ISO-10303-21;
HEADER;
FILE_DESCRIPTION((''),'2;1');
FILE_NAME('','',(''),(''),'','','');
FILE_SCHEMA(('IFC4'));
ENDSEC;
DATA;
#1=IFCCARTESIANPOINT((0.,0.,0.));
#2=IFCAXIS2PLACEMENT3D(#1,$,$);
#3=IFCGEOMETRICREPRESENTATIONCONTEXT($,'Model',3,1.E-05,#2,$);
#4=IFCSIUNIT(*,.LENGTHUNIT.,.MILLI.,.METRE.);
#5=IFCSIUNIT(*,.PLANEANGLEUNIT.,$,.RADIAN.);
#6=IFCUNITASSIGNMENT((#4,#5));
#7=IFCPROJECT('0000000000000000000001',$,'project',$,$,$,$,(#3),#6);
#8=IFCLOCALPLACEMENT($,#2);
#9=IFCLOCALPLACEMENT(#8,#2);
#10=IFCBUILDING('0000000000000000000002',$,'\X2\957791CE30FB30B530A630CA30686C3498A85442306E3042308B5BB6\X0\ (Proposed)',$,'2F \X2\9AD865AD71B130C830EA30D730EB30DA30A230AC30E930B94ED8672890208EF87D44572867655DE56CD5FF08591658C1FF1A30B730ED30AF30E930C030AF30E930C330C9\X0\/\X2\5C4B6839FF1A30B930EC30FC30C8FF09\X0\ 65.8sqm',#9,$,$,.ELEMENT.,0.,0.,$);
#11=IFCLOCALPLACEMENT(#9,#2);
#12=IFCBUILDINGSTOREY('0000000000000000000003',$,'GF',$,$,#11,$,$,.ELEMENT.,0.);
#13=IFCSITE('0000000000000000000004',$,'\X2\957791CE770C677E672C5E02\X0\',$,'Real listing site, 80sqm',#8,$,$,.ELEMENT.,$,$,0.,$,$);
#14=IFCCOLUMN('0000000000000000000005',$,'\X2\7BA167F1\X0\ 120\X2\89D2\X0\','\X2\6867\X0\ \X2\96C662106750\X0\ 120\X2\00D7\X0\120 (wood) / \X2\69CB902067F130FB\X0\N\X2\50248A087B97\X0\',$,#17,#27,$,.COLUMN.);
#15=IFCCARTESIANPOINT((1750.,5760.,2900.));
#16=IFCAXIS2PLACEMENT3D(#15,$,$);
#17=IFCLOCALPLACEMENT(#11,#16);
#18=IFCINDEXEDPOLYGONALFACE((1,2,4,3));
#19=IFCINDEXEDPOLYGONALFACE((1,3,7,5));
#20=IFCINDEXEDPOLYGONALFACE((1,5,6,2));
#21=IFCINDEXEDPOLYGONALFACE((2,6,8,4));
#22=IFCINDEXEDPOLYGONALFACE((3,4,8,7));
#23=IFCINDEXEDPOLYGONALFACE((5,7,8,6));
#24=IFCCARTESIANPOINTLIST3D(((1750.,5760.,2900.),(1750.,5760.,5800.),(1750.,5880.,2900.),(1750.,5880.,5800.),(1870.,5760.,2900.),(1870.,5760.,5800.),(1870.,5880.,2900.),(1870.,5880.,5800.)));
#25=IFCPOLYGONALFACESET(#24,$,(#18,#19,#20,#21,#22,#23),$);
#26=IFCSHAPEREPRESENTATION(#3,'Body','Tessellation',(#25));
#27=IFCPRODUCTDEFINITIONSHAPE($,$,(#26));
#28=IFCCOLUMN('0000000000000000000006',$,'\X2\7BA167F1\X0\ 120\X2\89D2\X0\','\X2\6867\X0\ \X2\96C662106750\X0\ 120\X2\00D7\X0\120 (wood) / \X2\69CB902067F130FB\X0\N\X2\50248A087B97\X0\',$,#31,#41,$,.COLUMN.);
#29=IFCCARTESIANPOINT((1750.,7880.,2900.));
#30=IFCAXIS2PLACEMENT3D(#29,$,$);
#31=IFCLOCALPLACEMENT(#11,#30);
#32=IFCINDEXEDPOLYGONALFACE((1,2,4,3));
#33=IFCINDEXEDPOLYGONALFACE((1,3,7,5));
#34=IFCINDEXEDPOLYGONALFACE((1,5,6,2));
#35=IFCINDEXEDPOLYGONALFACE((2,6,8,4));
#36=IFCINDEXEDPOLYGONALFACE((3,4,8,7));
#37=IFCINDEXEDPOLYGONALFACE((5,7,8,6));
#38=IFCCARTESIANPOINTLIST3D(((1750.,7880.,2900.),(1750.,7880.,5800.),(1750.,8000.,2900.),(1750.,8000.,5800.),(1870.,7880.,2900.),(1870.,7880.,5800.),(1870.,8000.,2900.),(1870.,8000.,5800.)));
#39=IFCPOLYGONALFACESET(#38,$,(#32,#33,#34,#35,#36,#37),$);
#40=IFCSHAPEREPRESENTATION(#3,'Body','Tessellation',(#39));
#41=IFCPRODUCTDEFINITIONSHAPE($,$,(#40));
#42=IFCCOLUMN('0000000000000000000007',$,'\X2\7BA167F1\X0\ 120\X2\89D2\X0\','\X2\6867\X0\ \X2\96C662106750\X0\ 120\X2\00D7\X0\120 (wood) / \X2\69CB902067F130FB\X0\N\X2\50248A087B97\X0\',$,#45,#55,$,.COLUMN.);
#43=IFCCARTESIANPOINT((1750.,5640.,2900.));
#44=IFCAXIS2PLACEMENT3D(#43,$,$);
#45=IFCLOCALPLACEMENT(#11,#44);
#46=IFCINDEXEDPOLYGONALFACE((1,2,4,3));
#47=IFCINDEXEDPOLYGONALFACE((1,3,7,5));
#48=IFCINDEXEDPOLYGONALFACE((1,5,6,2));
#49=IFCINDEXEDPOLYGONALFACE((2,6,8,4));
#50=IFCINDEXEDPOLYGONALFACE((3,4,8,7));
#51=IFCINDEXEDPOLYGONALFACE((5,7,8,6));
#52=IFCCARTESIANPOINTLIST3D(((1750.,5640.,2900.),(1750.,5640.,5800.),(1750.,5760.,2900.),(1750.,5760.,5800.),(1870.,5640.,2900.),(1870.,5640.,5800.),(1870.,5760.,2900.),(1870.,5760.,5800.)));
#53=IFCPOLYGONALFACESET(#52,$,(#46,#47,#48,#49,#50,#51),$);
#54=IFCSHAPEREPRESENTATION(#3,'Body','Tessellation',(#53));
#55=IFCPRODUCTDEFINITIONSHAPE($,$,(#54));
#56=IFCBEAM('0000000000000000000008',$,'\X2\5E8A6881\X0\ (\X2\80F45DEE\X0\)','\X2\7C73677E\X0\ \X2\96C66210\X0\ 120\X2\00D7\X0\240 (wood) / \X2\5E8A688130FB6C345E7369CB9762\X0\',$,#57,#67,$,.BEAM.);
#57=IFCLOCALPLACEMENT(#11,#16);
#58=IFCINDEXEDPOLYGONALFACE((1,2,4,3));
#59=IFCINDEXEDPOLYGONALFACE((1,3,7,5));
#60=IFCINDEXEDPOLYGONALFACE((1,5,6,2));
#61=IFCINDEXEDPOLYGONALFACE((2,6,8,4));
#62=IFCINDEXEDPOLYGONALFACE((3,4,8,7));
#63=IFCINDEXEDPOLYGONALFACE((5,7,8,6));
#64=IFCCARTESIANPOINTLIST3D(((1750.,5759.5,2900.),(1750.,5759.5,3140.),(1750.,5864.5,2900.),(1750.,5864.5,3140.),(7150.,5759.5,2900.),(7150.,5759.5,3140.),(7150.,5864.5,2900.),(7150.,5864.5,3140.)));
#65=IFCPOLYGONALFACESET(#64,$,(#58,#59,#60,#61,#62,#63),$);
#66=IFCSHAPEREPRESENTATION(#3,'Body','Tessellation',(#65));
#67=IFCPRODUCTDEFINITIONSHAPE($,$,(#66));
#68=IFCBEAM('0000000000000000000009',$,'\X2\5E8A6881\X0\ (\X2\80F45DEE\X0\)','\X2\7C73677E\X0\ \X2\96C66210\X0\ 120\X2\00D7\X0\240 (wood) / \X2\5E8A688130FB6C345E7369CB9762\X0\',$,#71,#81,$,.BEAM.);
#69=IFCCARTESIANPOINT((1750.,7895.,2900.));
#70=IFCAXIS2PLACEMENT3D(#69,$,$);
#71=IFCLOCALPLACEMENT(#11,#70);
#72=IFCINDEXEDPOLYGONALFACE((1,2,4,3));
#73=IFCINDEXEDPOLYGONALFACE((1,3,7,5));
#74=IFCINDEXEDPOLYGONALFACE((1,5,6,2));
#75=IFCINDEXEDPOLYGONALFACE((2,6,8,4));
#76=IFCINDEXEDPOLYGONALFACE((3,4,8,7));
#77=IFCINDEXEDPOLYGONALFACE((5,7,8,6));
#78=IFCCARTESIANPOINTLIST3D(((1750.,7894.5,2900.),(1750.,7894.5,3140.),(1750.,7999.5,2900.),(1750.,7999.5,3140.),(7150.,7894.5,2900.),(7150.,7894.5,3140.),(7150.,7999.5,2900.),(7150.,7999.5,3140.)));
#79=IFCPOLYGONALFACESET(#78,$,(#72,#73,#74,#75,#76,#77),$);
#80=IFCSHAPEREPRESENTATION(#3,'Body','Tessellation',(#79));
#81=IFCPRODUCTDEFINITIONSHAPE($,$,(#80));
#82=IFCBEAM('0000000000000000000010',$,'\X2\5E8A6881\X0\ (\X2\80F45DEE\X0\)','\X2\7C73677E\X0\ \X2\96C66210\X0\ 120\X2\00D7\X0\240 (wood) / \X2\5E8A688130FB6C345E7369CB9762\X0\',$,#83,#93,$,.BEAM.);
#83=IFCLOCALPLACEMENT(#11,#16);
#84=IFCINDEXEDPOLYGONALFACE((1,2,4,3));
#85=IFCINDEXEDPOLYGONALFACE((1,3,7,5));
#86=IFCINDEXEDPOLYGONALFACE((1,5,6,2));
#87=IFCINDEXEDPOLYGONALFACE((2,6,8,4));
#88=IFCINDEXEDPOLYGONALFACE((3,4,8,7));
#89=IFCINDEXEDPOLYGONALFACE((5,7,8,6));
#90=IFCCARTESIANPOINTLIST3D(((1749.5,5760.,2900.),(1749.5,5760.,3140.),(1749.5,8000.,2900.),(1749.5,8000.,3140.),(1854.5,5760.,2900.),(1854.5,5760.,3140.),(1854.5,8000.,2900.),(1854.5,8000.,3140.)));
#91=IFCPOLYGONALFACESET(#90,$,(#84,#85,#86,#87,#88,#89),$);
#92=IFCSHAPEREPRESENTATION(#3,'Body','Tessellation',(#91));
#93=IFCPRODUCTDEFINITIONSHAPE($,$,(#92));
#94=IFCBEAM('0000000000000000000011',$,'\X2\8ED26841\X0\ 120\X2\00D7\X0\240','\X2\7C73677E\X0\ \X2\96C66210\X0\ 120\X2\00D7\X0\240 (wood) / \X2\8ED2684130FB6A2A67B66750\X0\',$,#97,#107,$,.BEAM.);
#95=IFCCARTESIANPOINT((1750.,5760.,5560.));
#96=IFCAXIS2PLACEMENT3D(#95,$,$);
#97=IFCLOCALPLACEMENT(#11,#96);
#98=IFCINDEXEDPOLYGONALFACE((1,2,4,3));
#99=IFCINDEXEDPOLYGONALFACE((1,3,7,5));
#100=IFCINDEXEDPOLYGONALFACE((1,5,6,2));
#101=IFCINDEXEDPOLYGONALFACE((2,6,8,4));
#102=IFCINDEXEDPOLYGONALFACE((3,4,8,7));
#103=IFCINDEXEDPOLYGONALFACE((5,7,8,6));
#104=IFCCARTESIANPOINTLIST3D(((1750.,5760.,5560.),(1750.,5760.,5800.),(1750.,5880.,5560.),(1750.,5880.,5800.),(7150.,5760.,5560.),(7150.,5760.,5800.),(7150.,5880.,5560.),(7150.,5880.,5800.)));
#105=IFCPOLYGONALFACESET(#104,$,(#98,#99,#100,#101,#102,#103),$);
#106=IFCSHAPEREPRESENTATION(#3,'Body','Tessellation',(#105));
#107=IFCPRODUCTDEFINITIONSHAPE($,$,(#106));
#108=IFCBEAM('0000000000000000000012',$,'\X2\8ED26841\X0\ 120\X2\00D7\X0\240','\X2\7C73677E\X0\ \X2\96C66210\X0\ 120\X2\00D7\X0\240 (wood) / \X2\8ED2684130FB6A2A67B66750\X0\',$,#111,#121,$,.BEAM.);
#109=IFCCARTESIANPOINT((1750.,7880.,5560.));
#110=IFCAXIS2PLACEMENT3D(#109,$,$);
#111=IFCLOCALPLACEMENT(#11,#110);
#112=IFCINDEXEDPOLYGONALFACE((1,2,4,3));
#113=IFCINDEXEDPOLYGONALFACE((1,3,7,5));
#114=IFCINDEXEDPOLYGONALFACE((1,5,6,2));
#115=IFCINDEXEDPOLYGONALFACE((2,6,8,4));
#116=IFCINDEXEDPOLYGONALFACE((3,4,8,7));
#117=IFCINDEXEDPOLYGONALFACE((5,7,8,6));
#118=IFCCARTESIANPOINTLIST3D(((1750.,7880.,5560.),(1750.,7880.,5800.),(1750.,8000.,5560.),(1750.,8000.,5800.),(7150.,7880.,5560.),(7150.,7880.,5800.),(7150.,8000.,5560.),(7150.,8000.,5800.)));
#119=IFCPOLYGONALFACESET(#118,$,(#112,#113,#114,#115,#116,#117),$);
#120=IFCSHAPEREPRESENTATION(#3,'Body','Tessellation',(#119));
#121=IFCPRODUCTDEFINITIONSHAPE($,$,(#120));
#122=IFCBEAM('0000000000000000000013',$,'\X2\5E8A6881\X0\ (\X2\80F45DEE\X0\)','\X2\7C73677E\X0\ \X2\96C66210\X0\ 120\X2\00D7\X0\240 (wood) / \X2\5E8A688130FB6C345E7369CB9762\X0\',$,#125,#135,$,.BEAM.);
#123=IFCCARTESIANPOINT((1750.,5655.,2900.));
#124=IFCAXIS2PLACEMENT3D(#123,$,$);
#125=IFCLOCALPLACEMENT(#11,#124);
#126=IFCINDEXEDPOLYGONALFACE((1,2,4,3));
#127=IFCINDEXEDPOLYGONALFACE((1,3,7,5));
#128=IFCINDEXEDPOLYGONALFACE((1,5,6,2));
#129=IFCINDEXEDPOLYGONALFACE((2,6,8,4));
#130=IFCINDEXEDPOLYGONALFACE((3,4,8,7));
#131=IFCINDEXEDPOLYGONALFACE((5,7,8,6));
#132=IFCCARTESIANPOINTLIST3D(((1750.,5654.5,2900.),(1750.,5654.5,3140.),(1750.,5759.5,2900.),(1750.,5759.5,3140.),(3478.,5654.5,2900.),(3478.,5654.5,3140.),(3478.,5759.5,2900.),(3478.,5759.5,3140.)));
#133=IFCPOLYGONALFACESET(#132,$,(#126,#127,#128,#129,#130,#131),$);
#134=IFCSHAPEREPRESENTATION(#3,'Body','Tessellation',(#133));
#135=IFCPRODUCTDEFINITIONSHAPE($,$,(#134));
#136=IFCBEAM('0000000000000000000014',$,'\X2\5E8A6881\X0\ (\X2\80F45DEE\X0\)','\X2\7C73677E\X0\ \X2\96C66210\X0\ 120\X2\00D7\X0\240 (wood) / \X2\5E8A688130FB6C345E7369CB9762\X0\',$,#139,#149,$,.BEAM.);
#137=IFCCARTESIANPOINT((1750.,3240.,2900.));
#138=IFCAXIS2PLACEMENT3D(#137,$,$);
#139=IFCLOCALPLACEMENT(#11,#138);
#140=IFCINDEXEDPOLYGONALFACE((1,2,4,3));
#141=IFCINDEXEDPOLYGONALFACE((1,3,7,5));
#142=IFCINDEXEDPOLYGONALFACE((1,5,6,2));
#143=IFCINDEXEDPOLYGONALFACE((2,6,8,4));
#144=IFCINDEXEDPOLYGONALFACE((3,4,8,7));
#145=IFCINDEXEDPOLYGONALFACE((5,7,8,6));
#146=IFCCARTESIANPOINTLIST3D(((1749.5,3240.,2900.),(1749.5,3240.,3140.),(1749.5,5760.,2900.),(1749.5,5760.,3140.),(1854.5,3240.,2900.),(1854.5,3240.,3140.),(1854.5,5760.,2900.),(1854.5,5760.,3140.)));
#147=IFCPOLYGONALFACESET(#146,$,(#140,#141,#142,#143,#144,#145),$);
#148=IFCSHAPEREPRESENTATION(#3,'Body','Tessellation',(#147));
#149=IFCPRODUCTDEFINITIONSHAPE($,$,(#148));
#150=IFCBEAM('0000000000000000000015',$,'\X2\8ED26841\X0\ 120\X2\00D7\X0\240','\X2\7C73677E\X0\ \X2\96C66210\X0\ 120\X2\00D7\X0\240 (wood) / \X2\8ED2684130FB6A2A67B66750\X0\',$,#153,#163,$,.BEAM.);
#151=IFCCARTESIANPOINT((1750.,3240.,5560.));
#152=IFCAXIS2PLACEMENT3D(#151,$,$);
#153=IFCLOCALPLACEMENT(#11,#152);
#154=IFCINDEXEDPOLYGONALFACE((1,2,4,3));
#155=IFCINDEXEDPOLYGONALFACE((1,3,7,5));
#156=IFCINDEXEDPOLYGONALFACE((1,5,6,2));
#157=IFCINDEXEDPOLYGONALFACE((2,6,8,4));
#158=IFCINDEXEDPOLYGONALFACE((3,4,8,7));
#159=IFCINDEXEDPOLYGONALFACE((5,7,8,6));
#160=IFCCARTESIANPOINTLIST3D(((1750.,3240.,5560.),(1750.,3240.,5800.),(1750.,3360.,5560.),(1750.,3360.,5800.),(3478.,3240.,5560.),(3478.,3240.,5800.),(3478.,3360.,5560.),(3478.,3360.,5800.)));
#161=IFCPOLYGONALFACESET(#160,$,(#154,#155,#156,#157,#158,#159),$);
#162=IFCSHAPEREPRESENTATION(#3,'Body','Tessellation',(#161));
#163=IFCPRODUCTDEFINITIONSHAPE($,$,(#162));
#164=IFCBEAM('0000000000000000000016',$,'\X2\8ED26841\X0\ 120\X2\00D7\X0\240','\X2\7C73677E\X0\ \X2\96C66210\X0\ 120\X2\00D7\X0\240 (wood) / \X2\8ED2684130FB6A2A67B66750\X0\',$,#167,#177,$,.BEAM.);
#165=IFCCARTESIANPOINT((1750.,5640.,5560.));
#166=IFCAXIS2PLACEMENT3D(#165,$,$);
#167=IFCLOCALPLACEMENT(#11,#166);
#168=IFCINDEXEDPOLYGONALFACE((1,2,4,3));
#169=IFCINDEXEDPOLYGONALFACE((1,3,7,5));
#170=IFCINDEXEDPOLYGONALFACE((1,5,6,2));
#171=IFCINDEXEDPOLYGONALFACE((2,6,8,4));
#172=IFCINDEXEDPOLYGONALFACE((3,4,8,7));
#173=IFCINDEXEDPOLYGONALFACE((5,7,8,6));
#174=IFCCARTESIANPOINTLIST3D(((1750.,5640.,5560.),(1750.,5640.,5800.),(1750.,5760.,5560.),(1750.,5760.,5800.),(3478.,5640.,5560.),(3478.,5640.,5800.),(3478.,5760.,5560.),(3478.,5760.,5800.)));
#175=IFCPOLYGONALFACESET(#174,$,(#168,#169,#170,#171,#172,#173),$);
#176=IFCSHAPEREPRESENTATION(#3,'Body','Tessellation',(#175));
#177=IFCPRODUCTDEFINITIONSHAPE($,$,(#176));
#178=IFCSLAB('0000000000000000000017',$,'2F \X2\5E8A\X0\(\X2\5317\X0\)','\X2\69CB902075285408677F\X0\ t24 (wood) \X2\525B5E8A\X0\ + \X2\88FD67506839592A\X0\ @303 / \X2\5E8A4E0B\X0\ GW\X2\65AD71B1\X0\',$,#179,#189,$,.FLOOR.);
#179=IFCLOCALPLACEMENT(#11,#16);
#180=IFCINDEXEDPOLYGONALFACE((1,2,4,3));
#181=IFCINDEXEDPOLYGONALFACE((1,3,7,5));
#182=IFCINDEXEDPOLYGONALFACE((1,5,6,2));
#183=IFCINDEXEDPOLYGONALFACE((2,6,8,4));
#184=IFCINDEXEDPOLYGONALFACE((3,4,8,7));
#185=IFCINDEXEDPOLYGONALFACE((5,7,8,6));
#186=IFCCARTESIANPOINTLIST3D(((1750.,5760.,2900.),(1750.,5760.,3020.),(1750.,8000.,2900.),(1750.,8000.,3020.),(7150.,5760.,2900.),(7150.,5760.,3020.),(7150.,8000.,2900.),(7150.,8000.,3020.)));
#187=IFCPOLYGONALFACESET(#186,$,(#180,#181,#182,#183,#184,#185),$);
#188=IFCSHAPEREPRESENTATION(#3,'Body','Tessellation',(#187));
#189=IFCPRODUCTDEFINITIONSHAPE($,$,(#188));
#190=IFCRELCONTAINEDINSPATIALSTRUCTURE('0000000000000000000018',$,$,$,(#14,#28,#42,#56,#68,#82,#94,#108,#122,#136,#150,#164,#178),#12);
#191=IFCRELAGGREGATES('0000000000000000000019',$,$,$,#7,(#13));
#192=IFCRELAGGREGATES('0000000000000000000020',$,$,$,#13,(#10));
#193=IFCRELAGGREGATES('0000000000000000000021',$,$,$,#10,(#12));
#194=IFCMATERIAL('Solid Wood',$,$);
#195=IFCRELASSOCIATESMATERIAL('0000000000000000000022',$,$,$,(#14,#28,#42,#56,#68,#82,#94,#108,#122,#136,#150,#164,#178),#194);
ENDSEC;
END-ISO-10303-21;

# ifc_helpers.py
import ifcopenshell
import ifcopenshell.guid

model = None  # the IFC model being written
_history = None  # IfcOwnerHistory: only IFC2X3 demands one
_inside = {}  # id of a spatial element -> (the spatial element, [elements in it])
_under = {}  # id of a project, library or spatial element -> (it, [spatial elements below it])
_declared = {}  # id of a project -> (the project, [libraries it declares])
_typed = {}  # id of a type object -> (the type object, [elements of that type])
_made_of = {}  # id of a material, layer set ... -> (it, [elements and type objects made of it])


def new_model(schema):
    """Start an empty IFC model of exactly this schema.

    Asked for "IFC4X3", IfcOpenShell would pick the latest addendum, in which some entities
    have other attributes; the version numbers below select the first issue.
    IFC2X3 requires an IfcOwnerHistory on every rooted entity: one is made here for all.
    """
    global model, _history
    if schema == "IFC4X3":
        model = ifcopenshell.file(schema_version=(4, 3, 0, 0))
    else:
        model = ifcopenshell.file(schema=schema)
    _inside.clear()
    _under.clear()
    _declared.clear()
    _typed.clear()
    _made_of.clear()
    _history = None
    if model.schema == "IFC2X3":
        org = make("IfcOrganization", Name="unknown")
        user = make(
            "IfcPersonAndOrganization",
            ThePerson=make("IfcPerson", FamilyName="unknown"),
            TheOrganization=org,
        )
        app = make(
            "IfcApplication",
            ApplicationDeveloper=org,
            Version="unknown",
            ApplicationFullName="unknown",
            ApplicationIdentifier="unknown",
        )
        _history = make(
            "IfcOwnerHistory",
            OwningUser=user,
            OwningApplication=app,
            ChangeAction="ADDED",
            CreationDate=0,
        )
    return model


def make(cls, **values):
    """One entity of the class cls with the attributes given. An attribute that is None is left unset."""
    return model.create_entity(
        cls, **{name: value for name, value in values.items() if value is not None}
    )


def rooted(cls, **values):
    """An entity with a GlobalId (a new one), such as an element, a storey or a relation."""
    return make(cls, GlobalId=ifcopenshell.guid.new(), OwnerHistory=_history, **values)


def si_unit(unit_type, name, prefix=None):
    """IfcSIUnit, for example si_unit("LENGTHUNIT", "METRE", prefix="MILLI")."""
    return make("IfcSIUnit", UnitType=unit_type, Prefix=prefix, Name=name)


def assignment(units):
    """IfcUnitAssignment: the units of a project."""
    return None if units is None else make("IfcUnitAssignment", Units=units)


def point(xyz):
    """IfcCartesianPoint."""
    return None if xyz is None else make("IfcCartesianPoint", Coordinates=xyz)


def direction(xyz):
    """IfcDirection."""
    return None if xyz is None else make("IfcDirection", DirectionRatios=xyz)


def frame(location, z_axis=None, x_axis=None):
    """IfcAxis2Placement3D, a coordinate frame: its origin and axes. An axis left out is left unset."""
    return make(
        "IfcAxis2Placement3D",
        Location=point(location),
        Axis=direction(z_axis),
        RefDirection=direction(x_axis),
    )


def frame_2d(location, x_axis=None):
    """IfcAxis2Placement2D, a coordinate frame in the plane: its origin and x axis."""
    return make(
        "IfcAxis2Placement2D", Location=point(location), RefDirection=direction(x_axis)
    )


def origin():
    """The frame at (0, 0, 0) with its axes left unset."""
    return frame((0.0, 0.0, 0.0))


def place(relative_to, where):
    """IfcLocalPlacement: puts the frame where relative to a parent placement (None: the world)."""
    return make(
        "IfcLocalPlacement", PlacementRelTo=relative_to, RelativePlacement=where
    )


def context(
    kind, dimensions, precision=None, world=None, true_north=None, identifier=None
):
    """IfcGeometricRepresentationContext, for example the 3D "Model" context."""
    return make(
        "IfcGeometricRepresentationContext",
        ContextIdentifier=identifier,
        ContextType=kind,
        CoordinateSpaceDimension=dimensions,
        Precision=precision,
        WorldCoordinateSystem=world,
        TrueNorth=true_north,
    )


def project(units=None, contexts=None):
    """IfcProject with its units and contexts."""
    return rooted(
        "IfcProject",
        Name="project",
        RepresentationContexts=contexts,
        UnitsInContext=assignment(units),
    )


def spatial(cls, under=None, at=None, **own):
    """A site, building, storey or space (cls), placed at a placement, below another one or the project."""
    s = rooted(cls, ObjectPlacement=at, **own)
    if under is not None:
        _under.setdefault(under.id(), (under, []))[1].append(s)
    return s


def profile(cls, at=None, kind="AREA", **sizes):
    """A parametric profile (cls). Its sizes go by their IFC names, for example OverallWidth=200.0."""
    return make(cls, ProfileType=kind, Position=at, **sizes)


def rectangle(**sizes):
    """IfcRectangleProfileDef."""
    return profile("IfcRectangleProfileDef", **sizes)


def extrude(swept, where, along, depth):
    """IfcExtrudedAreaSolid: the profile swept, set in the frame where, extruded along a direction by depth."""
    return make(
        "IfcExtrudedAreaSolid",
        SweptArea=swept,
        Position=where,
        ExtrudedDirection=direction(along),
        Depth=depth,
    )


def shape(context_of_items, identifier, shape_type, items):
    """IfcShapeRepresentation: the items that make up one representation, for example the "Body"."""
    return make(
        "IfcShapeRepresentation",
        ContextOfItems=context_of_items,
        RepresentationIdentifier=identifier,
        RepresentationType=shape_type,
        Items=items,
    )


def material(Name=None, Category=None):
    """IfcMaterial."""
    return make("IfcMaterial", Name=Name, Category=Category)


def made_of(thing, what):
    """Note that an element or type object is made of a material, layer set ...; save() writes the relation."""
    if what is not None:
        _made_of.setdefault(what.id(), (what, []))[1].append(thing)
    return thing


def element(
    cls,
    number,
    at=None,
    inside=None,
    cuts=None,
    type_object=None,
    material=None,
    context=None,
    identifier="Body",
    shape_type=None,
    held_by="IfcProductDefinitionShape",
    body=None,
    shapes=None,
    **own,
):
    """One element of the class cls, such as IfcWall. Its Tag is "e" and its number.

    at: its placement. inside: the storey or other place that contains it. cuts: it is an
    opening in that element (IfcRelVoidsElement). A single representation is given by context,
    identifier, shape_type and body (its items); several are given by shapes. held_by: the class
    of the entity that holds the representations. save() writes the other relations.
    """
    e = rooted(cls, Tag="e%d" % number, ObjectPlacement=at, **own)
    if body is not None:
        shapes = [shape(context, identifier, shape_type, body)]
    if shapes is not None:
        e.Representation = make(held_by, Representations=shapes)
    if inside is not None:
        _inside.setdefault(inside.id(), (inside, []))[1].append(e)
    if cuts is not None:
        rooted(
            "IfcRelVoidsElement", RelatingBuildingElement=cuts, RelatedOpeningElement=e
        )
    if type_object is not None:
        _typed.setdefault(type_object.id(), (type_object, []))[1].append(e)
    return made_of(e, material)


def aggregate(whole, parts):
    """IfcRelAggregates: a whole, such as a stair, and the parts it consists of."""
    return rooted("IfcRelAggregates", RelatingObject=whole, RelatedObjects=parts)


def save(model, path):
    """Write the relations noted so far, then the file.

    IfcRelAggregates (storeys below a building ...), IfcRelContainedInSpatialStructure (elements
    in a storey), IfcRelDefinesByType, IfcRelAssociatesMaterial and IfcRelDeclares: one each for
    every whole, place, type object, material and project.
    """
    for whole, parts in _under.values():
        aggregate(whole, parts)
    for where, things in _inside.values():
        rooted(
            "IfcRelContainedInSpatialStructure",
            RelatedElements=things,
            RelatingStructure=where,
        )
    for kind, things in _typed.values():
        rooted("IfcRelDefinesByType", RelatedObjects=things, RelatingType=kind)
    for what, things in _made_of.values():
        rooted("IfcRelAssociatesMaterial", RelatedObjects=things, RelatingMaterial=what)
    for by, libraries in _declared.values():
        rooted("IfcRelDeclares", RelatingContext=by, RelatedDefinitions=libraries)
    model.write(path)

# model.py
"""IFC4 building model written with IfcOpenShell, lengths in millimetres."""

from ifc_helpers import new_model, si_unit, frame, frame_2d, origin, place, context, project, spatial, rectangle, extrude, material, element, save


model = new_model("IFC4")

# Units and contexts
model_context = context("Model", 3, precision=1e-05, world=origin())
ifc_project = project(units=[si_unit("LENGTHUNIT", "METRE", prefix="MILLI"), si_unit("PLANEANGLEUNIT", "RADIAN")], contexts=[model_context])

# Site, building, storey
site_placement = place(None, origin())
site = spatial("IfcSite", under=ifc_project, at=site_placement, Name="長野県松本市", ObjectType="Real listing site, 80sqm", CompositionType="ELEMENT", RefElevation=0.0)
building_placement = place(site_placement, origin())
building = spatial("IfcBuilding", under=site, at=building_placement, Name="長野・サウナと水風呂のある家 (Proposed)", ObjectType="2F 高断熱トリプルペアガラス付木造軸組在来工法（外壁：シロクラダクラッド/屋根：スレート） 65.8sqm", CompositionType="ELEMENT", ElevationOfRefHeight=0.0, ElevationOfTerrain=0.0)
storey_placement = place(building_placement, origin())
storey = spatial("IfcBuildingStorey", under=building, at=storey_placement, Name="GF", CompositionType="ELEMENT", Elevation=0.0)

# Columns
ifc_material_1 = material(Name="Solid Wood")
column_1_placement = place(storey_placement, frame((1750.0, 5760.0, 2900.0)))
element("IfcColumn", 1, at=column_1_placement, inside=storey, material=ifc_material_1, Name="管柱 120角", Description="桧 集成材 120×120 (wood) / 構造柱・N値計算", PredefinedType="COLUMN", context=model_context, shape_type="SweptSolid", body=[
    extrude(rectangle(XDim=120.0, YDim=120.0, at=frame_2d((60.0, 60.0))), frame((1750.0, 5760.0, 2900.0)), (0.0, 0.0, 1.0), 2900.0),
])
column_2_placement = place(storey_placement, frame((1750.0, 7880.0, 2900.0)))
element("IfcColumn", 2, at=column_2_placement, inside=storey, material=ifc_material_1, Name="管柱 120角", Description="桧 集成材 120×120 (wood) / 構造柱・N値計算", PredefinedType="COLUMN", context=model_context, shape_type="SweptSolid", body=[
    extrude(rectangle(XDim=120.0, YDim=120.0, at=frame_2d((60.0, 60.0))), frame((1750.0, 7880.0, 2900.0)), (0.0, 0.0, 1.0), 2900.0),
])
column_3_placement = place(storey_placement, frame((1750.0, 5640.0, 2900.0)))
element("IfcColumn", 3, at=column_3_placement, inside=storey, material=ifc_material_1, Name="管柱 120角", Description="桧 集成材 120×120 (wood) / 構造柱・N値計算", PredefinedType="COLUMN", context=model_context, shape_type="SweptSolid", body=[
    extrude(rectangle(XDim=120.0, YDim=120.0, at=frame_2d((60.0, 60.0))), frame((1750.0, 5640.0, 2900.0)), (0.0, 0.0, 1.0), 2900.0),
])

# Beams
beam_1_placement = place(storey_placement, frame((1750.0, 5760.0, 2900.0)))
element("IfcBeam", 4, at=beam_1_placement, inside=storey, material=ifc_material_1, Name="床梁 (胴差)", Description="米松 集成 120×240 (wood) / 床梁・水平構面", PredefinedType="BEAM", context=model_context, shape_type="SweptSolid", body=[
    extrude(rectangle(XDim=5400.0, YDim=105.0, at=frame_2d((2700.0, 52.0))), frame((1750.0, 5760.0, 2900.0)), (0.0, 0.0, 1.0), 240.0),
])
beam_2_placement = place(storey_placement, frame((1750.0, 7895.0, 2900.0)))
element("IfcBeam", 5, at=beam_2_placement, inside=storey, material=ifc_material_1, Name="床梁 (胴差)", Description="米松 集成 120×240 (wood) / 床梁・水平構面", PredefinedType="BEAM", context=model_context, shape_type="SweptSolid", body=[
    extrude(rectangle(XDim=5400.0, YDim=105.0, at=frame_2d((2700.0, 52.0))), frame((1750.0, 7895.0, 2900.0)), (0.0, 0.0, 1.0), 240.0),
])
beam_3_placement = place(storey_placement, frame((1750.0, 5760.0, 2900.0)))
element("IfcBeam", 6, at=beam_3_placement, inside=storey, material=ifc_material_1, Name="床梁 (胴差)", Description="米松 集成 120×240 (wood) / 床梁・水平構面", PredefinedType="BEAM", context=model_context, shape_type="SweptSolid", body=[
    extrude(rectangle(XDim=105.0, YDim=2240.0, at=frame_2d((52.0, 1120.0))), frame((1750.0, 5760.0, 2900.0)), (0.0, 0.0, 1.0), 240.0),
])
beam_4_placement = place(storey_placement, frame((1750.0, 5760.0, 5560.0)))
element("IfcBeam", 7, at=beam_4_placement, inside=storey, material=ifc_material_1, Name="軒桁 120×240", Description="米松 集成 120×240 (wood) / 軒桁・横架材", PredefinedType="BEAM", context=model_context, shape_type="SweptSolid", body=[
    extrude(rectangle(XDim=5400.0, YDim=120.0, at=frame_2d((2700.0, 60.0))), frame((1750.0, 5760.0, 5560.0)), (0.0, 0.0, 1.0), 240.0),
])
beam_5_placement = place(storey_placement, frame((1750.0, 7880.0, 5560.0)))
element("IfcBeam", 8, at=beam_5_placement, inside=storey, material=ifc_material_1, Name="軒桁 120×240", Description="米松 集成 120×240 (wood) / 軒桁・横架材", PredefinedType="BEAM", context=model_context, shape_type="SweptSolid", body=[
    extrude(rectangle(XDim=5400.0, YDim=120.0, at=frame_2d((2700.0, 60.0))), frame((1750.0, 7880.0, 5560.0)), (0.0, 0.0, 1.0), 240.0),
])
beam_6_placement = place(storey_placement, frame((1750.0, 5655.0, 2900.0)))
element("IfcBeam", 9, at=beam_6_placement, inside=storey, material=ifc_material_1, Name="床梁 (胴差)", Description="米松 集成 120×240 (wood) / 床梁・水平構面", PredefinedType="BEAM", context=model_context, shape_type="SweptSolid", body=[
    extrude(rectangle(XDim=1728.0, YDim=105.0, at=frame_2d((864.0, 52.0))), frame((1750.0, 5655.0, 2900.0)), (0.0, 0.0, 1.0), 240.0),
])
beam_7_placement = place(storey_placement, frame((1750.0, 3240.0, 2900.0)))
element("IfcBeam", 10, at=beam_7_placement, inside=storey, material=ifc_material_1, Name="床梁 (胴差)", Description="米松 集成 120×240 (wood) / 床梁・水平構面", PredefinedType="BEAM", context=model_context, shape_type="SweptSolid", body=[
    extrude(rectangle(XDim=105.0, YDim=2520.0, at=frame_2d((52.0, 1260.0))), frame((1750.0, 3240.0, 2900.0)), (0.0, 0.0, 1.0), 240.0),
])
beam_8_placement = place(storey_placement, frame((1750.0, 3240.0, 5560.0)))
element("IfcBeam", 11, at=beam_8_placement, inside=storey, material=ifc_material_1, Name="軒桁 120×240", Description="米松 集成 120×240 (wood) / 軒桁・横架材", PredefinedType="BEAM", context=model_context, shape_type="SweptSolid", body=[
    extrude(rectangle(XDim=1728.0, YDim=120.0, at=frame_2d((864.0, 60.0))), frame((1750.0, 3240.0, 5560.0)), (0.0, 0.0, 1.0), 240.0),
])
beam_9_placement = place(storey_placement, frame((1750.0, 5640.0, 5560.0)))
element("IfcBeam", 12, at=beam_9_placement, inside=storey, material=ifc_material_1, Name="軒桁 120×240", Description="米松 集成 120×240 (wood) / 軒桁・横架材", PredefinedType="BEAM", context=model_context, shape_type="SweptSolid", body=[
    extrude(rectangle(XDim=1728.0, YDim=120.0, at=frame_2d((864.0, 60.0))), frame((1750.0, 5640.0, 5560.0)), (0.0, 0.0, 1.0), 240.0),
])

# Slab
slab_placement = place(storey_placement, frame((1750.0, 5760.0, 2900.0)))
element("IfcSlab", 13, at=slab_placement, inside=storey, material=ifc_material_1, Name="2F 床(北)", Description="構造用合板 t24 (wood) 剛床 + 製材根太 @303 / 床下 GW断熱", PredefinedType="FLOOR", context=model_context, shape_type="SweptSolid", body=[
    extrude(rectangle(XDim=5400.0, YDim=2240.0, at=frame_2d((2700.0, 1120.0))), frame((1750.0, 5760.0, 2900.0)), (0.0, 0.0, 1.0), 120.0),
])

save(model, "model.ifc")
